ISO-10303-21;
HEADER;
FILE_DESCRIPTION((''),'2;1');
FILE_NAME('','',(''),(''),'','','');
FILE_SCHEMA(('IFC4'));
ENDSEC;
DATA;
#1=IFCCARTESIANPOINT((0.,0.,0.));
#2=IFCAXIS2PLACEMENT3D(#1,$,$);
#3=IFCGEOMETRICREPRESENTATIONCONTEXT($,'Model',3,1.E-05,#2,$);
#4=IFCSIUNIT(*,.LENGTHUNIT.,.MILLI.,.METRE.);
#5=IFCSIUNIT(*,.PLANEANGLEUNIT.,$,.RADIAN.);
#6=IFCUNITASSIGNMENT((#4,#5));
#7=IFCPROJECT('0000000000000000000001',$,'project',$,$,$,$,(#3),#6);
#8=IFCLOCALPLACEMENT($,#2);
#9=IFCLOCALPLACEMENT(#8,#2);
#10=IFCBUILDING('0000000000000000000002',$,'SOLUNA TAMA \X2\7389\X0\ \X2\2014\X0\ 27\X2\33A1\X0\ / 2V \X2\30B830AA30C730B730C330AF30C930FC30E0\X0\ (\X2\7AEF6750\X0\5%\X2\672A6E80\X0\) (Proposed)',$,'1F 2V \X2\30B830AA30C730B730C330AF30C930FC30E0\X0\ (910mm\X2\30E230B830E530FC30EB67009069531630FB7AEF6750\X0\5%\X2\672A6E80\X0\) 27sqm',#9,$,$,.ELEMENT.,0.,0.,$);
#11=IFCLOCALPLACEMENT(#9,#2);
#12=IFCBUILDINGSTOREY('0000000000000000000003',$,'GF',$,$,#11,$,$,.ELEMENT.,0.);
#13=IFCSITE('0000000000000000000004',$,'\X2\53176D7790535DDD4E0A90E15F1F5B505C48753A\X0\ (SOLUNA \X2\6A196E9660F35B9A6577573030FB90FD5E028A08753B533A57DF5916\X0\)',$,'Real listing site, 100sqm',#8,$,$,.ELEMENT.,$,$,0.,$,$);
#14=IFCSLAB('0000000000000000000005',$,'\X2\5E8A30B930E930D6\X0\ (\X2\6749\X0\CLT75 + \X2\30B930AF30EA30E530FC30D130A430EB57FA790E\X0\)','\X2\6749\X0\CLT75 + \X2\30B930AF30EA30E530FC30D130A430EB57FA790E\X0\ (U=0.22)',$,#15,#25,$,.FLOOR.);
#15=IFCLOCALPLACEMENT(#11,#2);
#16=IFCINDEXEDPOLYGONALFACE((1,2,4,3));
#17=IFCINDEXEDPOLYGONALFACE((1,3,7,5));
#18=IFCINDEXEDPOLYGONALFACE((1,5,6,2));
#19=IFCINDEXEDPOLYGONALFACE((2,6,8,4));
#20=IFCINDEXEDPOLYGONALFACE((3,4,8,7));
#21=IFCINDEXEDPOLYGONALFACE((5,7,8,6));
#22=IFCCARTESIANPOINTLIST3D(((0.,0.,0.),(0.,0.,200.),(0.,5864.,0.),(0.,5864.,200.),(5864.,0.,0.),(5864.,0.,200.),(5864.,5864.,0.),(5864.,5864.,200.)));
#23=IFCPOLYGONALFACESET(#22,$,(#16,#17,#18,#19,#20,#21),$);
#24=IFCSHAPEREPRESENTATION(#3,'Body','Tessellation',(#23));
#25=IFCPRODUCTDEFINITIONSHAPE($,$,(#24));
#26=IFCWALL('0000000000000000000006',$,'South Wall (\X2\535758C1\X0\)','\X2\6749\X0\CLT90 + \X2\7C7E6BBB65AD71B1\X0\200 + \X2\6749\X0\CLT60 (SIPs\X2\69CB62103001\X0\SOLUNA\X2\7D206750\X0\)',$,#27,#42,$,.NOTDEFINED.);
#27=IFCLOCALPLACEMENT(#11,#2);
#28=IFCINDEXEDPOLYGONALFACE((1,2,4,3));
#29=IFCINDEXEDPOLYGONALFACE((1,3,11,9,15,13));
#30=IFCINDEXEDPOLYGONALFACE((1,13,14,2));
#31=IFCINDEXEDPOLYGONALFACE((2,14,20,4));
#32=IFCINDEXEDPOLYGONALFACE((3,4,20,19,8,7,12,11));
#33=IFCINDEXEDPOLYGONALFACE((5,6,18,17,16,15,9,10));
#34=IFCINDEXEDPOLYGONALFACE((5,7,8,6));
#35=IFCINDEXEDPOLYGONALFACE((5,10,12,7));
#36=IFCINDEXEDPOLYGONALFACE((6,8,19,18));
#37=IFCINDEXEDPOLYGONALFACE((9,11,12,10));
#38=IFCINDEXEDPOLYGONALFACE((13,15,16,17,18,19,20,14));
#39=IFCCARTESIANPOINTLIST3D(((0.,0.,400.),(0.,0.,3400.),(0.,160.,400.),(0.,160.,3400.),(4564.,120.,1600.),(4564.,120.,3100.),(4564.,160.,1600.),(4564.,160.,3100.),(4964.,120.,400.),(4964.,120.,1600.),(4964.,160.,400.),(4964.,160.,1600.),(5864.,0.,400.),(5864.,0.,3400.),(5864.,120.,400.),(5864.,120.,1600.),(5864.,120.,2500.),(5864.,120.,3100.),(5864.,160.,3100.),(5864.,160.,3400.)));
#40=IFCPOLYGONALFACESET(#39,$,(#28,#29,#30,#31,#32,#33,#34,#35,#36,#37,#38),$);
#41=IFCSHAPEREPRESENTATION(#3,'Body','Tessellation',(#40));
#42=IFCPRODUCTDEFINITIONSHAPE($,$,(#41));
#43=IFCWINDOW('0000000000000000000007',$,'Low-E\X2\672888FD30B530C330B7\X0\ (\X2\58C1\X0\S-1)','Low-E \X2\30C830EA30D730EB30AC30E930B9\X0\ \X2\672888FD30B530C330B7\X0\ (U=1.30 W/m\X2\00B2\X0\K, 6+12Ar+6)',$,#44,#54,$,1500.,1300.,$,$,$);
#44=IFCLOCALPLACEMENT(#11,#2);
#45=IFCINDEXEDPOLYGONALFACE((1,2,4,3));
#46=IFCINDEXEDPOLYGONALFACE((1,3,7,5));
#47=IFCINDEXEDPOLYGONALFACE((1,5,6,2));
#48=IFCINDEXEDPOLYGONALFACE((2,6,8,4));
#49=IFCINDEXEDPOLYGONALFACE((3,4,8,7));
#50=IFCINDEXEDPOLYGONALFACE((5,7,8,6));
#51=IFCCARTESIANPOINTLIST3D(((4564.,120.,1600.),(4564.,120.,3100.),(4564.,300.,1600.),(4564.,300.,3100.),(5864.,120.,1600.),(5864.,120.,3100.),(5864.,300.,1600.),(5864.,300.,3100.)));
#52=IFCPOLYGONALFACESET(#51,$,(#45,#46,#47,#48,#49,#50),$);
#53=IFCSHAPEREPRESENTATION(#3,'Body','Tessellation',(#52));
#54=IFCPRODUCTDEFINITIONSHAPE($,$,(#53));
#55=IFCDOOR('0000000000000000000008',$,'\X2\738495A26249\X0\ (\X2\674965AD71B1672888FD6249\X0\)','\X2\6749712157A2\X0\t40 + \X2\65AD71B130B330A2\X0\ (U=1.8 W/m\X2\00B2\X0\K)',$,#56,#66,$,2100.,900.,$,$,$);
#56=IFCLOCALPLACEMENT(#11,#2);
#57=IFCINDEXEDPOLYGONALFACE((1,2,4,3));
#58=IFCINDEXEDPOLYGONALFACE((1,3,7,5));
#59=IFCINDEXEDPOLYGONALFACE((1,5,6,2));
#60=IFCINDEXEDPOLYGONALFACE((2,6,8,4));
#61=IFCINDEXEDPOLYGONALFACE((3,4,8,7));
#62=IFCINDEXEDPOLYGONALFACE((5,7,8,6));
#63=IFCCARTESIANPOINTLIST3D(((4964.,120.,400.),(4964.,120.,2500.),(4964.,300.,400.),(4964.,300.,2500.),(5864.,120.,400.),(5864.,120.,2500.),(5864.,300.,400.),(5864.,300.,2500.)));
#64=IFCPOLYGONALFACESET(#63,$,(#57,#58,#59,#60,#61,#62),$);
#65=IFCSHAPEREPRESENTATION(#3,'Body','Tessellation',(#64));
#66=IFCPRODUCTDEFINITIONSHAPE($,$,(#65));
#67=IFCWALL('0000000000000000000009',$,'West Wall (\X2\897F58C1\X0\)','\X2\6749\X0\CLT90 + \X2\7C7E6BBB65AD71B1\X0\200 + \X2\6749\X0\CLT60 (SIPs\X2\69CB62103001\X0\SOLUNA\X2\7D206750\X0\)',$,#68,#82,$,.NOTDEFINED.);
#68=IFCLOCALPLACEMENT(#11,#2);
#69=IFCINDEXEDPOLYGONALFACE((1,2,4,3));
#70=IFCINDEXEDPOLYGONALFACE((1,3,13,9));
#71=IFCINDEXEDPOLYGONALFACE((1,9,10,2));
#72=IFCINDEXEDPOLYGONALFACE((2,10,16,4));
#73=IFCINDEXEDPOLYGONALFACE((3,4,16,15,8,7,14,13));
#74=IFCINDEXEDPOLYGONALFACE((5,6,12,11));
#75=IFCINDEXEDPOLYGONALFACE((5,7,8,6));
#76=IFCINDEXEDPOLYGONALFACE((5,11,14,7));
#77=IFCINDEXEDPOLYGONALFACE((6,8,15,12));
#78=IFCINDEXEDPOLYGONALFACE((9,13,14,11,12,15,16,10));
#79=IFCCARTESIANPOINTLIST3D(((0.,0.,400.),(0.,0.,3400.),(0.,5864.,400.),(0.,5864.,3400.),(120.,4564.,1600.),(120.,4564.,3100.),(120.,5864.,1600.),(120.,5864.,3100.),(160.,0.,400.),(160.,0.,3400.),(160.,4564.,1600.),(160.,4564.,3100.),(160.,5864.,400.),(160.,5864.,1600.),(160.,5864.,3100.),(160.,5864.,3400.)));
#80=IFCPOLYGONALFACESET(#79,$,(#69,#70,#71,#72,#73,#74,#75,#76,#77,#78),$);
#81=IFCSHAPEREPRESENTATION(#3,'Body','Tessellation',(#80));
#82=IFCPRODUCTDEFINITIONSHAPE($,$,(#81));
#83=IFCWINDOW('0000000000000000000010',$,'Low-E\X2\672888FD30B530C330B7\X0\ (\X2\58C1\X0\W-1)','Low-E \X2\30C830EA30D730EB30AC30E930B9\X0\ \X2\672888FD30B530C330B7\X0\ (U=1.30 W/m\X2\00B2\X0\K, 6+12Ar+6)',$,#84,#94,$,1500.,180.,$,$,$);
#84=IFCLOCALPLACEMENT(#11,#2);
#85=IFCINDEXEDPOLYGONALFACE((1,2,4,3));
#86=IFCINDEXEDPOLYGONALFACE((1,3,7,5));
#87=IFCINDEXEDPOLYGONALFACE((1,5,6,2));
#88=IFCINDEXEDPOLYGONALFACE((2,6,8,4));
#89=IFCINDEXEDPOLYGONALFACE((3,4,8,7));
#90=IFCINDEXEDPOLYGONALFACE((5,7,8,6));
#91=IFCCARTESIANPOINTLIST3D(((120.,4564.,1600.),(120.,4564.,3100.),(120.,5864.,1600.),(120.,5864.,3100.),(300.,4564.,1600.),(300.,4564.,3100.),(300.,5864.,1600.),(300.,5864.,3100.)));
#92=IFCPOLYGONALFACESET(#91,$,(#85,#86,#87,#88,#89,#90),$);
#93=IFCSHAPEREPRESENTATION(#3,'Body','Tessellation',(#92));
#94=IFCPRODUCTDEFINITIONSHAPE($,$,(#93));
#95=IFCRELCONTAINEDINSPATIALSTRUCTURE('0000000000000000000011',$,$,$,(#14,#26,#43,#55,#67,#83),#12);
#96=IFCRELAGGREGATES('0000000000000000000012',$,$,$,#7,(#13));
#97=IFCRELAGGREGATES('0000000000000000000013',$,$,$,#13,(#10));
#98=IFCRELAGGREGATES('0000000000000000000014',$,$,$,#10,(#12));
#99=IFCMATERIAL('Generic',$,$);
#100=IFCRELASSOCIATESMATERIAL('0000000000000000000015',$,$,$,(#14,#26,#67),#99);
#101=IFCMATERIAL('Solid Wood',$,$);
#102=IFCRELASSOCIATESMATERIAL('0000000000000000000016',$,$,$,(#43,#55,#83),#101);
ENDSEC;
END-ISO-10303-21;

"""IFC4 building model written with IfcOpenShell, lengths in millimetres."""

from ifc_helpers import new_model, si_unit, frame, frame_2d, origin, place, context, project, spatial, rectangle, extrude, material, element, fill, save


model = new_model("IFC4")

# Units and contexts
model_context = context("Model", 3, precision=1e-05, world=origin())
ifc_project = project(units=[si_unit("LENGTHUNIT", "METRE", prefix="MILLI"), si_unit("PLANEANGLEUNIT", "RADIAN")], contexts=[model_context])

# Site, building, storey
site_placement = place(None, origin())
site = spatial("IfcSite", under=ifc_project, at=site_placement, Name="北海道川上郡弟子屈町 (SOLUNA 標準想定敷地・都市計画区域外)", ObjectType="Real listing site, 100sqm", CompositionType="ELEMENT", RefElevation=0.0)
building_placement = place(site_placement, origin())
building = spatial("IfcBuilding", under=site, at=building_placement, Name="SOLUNA TAMA 玉 — 27㎡ / 2V ジオデシックドーム (端材5%未満) (Proposed)", ObjectType="1F 2V ジオデシックドーム (910mmモジュール最適化・端材5%未満) 27sqm", CompositionType="ELEMENT", ElevationOfRefHeight=0.0, ElevationOfTerrain=0.0)
storey_placement = place(building_placement, origin())
storey = spatial("IfcBuildingStorey", under=building, at=storey_placement, Name="GF", CompositionType="ELEMENT", Elevation=0.0)

# Slab
ifc_material_1 = material(Name="Generic")
slab_placement = place(storey_placement, origin())
element("IfcSlab", 1, at=slab_placement, inside=storey, material=ifc_material_1, Name="床スラブ (杉CLT75 + スクリューパイル基礎)", Description="杉CLT75 + スクリューパイル基礎 (U=0.22)", PredefinedType="FLOOR", context=model_context, shape_type="SweptSolid", body=[
    extrude(rectangle(XDim=5864.0, YDim=5864.0, at=frame_2d((2932.0, 2932.0))), origin(), (0.0, 0.0, 1.0), 200.0),
])

# Wall, openings, window, door
wall_1_placement = place(storey_placement, frame((0.0, 0.0, 200.0)))
wall_1 = element("IfcWall", 2, at=wall_1_placement, inside=storey, material=ifc_material_1, Name="South Wall (南壁)", Description="杉CLT90 + 籾殻断熱200 + 杉CLT60 (SIPs構成、SOLUNA素材)", PredefinedType="NOTDEFINED", context=model_context, shape_type="SweptSolid", body=[
    extrude(rectangle(XDim=5864.0, YDim=160.0, at=frame_2d((2932.0, 80.0))), frame((0.0, 0.0, 200.0)), (0.0, 0.0, 1.0), 3000.0),
])
opening_1_placement = place(storey_placement, frame((2282.0, 60.0, 800.0)))
opening_1 = element("IfcOpeningElement", 3, at=opening_1_placement, cuts=wall_1, PredefinedType="NOTDEFINED", context=model_context, shape_type="SweptSolid", body=[
    extrude(rectangle(XDim=1300.0, YDim=180.0, at=frame_2d((650.0, 90.0))), frame((2282.0, 60.0, 800.0)), (0.0, 0.0, 1.0), 1500.0),
])
opening_2_placement = place(storey_placement, frame((2482.0, 60.0, 200.0)))
opening_2 = element("IfcOpeningElement", 4, at=opening_2_placement, cuts=wall_1, PredefinedType="NOTDEFINED", context=model_context, shape_type="SweptSolid", body=[
    extrude(rectangle(XDim=900.0, YDim=180.0, at=frame_2d((450.0, 90.0))), frame((2482.0, 60.0, 200.0)), (0.0, 0.0, 1.0), 2100.0),
])
ifc_material_2 = material(Name="Solid Wood")
window_1_placement = place(storey_placement, frame((2282.0, 60.0, 800.0)))
window_1 = element("IfcWindow", 5, at=window_1_placement, inside=storey, material=ifc_material_2, Name="Low-E木製サッシ (壁S-1)", Description="Low-E トリプルガラス 木製サッシ (U=1.30 W/m²K, 6+12Ar+6)", OverallHeight=1500.0, OverallWidth=1300.0, context=model_context, shape_type="SweptSolid", body=[
    extrude(rectangle(XDim=1300.0, YDim=180.0, at=frame_2d((650.0, 90.0))), frame((2282.0, 60.0, 800.0)), (0.0, 0.0, 1.0), 1500.0),
])
fill(opening_1, window_1)
door_placement = place(storey_placement, frame((2482.0, 60.0, 200.0)))
door = element("IfcDoor", 6, at=door_placement, inside=storey, material=ifc_material_2, Name="玄関扉 (杉断熱木製扉)", Description="杉無垢t40 + 断熱コア (U=1.8 W/m²K)", OverallHeight=2100.0, OverallWidth=900.0, context=model_context, shape_type="SweptSolid", body=[
    extrude(rectangle(XDim=900.0, YDim=180.0, at=frame_2d((450.0, 90.0))), frame((2482.0, 60.0, 200.0)), (0.0, 0.0, 1.0), 2100.0),
])
fill(opening_2, door)

# Wall, opening, window
wall_2_placement = place(storey_placement, frame((0.0, 0.0, 200.0)))
wall_2 = element("IfcWall", 7, at=wall_2_placement, inside=storey, material=ifc_material_1, Name="West Wall (西壁)", Description="杉CLT90 + 籾殻断熱200 + 杉CLT60 (SIPs構成、SOLUNA素材)", PredefinedType="NOTDEFINED", context=model_context, shape_type="SweptSolid", body=[
    extrude(rectangle(XDim=160.0, YDim=5864.0, at=frame_2d((80.0, 2932.0))), frame((0.0, 0.0, 200.0)), (0.0, 0.0, 1.0), 3000.0),
])
opening_3_placement = place(storey_placement, frame((60.0, 2282.0, 800.0)))
opening_3 = element("IfcOpeningElement", 8, at=opening_3_placement, cuts=wall_2, PredefinedType="NOTDEFINED", context=model_context, shape_type="SweptSolid", body=[
    extrude(rectangle(XDim=180.0, YDim=1300.0, at=frame_2d((90.0, 650.0))), frame((60.0, 2282.0, 800.0)), (0.0, 0.0, 1.0), 1500.0),
])
window_2_placement = place(storey_placement, frame((60.0, 2282.0, 800.0)))
window_2 = element("IfcWindow", 9, at=window_2_placement, inside=storey, material=ifc_material_2, Name="Low-E木製サッシ (壁W-1)", Description="Low-E トリプルガラス 木製サッシ (U=1.30 W/m²K, 6+12Ar+6)", OverallHeight=1500.0, OverallWidth=180.0, context=model_context, shape_type="SweptSolid", body=[
    extrude(rectangle(XDim=180.0, YDim=1300.0, at=frame_2d((90.0, 650.0))), frame((60.0, 2282.0, 800.0)), (0.0, 0.0, 1.0), 1500.0),
])
fill(opening_3, window_2)

save(model, "model.ifc")
